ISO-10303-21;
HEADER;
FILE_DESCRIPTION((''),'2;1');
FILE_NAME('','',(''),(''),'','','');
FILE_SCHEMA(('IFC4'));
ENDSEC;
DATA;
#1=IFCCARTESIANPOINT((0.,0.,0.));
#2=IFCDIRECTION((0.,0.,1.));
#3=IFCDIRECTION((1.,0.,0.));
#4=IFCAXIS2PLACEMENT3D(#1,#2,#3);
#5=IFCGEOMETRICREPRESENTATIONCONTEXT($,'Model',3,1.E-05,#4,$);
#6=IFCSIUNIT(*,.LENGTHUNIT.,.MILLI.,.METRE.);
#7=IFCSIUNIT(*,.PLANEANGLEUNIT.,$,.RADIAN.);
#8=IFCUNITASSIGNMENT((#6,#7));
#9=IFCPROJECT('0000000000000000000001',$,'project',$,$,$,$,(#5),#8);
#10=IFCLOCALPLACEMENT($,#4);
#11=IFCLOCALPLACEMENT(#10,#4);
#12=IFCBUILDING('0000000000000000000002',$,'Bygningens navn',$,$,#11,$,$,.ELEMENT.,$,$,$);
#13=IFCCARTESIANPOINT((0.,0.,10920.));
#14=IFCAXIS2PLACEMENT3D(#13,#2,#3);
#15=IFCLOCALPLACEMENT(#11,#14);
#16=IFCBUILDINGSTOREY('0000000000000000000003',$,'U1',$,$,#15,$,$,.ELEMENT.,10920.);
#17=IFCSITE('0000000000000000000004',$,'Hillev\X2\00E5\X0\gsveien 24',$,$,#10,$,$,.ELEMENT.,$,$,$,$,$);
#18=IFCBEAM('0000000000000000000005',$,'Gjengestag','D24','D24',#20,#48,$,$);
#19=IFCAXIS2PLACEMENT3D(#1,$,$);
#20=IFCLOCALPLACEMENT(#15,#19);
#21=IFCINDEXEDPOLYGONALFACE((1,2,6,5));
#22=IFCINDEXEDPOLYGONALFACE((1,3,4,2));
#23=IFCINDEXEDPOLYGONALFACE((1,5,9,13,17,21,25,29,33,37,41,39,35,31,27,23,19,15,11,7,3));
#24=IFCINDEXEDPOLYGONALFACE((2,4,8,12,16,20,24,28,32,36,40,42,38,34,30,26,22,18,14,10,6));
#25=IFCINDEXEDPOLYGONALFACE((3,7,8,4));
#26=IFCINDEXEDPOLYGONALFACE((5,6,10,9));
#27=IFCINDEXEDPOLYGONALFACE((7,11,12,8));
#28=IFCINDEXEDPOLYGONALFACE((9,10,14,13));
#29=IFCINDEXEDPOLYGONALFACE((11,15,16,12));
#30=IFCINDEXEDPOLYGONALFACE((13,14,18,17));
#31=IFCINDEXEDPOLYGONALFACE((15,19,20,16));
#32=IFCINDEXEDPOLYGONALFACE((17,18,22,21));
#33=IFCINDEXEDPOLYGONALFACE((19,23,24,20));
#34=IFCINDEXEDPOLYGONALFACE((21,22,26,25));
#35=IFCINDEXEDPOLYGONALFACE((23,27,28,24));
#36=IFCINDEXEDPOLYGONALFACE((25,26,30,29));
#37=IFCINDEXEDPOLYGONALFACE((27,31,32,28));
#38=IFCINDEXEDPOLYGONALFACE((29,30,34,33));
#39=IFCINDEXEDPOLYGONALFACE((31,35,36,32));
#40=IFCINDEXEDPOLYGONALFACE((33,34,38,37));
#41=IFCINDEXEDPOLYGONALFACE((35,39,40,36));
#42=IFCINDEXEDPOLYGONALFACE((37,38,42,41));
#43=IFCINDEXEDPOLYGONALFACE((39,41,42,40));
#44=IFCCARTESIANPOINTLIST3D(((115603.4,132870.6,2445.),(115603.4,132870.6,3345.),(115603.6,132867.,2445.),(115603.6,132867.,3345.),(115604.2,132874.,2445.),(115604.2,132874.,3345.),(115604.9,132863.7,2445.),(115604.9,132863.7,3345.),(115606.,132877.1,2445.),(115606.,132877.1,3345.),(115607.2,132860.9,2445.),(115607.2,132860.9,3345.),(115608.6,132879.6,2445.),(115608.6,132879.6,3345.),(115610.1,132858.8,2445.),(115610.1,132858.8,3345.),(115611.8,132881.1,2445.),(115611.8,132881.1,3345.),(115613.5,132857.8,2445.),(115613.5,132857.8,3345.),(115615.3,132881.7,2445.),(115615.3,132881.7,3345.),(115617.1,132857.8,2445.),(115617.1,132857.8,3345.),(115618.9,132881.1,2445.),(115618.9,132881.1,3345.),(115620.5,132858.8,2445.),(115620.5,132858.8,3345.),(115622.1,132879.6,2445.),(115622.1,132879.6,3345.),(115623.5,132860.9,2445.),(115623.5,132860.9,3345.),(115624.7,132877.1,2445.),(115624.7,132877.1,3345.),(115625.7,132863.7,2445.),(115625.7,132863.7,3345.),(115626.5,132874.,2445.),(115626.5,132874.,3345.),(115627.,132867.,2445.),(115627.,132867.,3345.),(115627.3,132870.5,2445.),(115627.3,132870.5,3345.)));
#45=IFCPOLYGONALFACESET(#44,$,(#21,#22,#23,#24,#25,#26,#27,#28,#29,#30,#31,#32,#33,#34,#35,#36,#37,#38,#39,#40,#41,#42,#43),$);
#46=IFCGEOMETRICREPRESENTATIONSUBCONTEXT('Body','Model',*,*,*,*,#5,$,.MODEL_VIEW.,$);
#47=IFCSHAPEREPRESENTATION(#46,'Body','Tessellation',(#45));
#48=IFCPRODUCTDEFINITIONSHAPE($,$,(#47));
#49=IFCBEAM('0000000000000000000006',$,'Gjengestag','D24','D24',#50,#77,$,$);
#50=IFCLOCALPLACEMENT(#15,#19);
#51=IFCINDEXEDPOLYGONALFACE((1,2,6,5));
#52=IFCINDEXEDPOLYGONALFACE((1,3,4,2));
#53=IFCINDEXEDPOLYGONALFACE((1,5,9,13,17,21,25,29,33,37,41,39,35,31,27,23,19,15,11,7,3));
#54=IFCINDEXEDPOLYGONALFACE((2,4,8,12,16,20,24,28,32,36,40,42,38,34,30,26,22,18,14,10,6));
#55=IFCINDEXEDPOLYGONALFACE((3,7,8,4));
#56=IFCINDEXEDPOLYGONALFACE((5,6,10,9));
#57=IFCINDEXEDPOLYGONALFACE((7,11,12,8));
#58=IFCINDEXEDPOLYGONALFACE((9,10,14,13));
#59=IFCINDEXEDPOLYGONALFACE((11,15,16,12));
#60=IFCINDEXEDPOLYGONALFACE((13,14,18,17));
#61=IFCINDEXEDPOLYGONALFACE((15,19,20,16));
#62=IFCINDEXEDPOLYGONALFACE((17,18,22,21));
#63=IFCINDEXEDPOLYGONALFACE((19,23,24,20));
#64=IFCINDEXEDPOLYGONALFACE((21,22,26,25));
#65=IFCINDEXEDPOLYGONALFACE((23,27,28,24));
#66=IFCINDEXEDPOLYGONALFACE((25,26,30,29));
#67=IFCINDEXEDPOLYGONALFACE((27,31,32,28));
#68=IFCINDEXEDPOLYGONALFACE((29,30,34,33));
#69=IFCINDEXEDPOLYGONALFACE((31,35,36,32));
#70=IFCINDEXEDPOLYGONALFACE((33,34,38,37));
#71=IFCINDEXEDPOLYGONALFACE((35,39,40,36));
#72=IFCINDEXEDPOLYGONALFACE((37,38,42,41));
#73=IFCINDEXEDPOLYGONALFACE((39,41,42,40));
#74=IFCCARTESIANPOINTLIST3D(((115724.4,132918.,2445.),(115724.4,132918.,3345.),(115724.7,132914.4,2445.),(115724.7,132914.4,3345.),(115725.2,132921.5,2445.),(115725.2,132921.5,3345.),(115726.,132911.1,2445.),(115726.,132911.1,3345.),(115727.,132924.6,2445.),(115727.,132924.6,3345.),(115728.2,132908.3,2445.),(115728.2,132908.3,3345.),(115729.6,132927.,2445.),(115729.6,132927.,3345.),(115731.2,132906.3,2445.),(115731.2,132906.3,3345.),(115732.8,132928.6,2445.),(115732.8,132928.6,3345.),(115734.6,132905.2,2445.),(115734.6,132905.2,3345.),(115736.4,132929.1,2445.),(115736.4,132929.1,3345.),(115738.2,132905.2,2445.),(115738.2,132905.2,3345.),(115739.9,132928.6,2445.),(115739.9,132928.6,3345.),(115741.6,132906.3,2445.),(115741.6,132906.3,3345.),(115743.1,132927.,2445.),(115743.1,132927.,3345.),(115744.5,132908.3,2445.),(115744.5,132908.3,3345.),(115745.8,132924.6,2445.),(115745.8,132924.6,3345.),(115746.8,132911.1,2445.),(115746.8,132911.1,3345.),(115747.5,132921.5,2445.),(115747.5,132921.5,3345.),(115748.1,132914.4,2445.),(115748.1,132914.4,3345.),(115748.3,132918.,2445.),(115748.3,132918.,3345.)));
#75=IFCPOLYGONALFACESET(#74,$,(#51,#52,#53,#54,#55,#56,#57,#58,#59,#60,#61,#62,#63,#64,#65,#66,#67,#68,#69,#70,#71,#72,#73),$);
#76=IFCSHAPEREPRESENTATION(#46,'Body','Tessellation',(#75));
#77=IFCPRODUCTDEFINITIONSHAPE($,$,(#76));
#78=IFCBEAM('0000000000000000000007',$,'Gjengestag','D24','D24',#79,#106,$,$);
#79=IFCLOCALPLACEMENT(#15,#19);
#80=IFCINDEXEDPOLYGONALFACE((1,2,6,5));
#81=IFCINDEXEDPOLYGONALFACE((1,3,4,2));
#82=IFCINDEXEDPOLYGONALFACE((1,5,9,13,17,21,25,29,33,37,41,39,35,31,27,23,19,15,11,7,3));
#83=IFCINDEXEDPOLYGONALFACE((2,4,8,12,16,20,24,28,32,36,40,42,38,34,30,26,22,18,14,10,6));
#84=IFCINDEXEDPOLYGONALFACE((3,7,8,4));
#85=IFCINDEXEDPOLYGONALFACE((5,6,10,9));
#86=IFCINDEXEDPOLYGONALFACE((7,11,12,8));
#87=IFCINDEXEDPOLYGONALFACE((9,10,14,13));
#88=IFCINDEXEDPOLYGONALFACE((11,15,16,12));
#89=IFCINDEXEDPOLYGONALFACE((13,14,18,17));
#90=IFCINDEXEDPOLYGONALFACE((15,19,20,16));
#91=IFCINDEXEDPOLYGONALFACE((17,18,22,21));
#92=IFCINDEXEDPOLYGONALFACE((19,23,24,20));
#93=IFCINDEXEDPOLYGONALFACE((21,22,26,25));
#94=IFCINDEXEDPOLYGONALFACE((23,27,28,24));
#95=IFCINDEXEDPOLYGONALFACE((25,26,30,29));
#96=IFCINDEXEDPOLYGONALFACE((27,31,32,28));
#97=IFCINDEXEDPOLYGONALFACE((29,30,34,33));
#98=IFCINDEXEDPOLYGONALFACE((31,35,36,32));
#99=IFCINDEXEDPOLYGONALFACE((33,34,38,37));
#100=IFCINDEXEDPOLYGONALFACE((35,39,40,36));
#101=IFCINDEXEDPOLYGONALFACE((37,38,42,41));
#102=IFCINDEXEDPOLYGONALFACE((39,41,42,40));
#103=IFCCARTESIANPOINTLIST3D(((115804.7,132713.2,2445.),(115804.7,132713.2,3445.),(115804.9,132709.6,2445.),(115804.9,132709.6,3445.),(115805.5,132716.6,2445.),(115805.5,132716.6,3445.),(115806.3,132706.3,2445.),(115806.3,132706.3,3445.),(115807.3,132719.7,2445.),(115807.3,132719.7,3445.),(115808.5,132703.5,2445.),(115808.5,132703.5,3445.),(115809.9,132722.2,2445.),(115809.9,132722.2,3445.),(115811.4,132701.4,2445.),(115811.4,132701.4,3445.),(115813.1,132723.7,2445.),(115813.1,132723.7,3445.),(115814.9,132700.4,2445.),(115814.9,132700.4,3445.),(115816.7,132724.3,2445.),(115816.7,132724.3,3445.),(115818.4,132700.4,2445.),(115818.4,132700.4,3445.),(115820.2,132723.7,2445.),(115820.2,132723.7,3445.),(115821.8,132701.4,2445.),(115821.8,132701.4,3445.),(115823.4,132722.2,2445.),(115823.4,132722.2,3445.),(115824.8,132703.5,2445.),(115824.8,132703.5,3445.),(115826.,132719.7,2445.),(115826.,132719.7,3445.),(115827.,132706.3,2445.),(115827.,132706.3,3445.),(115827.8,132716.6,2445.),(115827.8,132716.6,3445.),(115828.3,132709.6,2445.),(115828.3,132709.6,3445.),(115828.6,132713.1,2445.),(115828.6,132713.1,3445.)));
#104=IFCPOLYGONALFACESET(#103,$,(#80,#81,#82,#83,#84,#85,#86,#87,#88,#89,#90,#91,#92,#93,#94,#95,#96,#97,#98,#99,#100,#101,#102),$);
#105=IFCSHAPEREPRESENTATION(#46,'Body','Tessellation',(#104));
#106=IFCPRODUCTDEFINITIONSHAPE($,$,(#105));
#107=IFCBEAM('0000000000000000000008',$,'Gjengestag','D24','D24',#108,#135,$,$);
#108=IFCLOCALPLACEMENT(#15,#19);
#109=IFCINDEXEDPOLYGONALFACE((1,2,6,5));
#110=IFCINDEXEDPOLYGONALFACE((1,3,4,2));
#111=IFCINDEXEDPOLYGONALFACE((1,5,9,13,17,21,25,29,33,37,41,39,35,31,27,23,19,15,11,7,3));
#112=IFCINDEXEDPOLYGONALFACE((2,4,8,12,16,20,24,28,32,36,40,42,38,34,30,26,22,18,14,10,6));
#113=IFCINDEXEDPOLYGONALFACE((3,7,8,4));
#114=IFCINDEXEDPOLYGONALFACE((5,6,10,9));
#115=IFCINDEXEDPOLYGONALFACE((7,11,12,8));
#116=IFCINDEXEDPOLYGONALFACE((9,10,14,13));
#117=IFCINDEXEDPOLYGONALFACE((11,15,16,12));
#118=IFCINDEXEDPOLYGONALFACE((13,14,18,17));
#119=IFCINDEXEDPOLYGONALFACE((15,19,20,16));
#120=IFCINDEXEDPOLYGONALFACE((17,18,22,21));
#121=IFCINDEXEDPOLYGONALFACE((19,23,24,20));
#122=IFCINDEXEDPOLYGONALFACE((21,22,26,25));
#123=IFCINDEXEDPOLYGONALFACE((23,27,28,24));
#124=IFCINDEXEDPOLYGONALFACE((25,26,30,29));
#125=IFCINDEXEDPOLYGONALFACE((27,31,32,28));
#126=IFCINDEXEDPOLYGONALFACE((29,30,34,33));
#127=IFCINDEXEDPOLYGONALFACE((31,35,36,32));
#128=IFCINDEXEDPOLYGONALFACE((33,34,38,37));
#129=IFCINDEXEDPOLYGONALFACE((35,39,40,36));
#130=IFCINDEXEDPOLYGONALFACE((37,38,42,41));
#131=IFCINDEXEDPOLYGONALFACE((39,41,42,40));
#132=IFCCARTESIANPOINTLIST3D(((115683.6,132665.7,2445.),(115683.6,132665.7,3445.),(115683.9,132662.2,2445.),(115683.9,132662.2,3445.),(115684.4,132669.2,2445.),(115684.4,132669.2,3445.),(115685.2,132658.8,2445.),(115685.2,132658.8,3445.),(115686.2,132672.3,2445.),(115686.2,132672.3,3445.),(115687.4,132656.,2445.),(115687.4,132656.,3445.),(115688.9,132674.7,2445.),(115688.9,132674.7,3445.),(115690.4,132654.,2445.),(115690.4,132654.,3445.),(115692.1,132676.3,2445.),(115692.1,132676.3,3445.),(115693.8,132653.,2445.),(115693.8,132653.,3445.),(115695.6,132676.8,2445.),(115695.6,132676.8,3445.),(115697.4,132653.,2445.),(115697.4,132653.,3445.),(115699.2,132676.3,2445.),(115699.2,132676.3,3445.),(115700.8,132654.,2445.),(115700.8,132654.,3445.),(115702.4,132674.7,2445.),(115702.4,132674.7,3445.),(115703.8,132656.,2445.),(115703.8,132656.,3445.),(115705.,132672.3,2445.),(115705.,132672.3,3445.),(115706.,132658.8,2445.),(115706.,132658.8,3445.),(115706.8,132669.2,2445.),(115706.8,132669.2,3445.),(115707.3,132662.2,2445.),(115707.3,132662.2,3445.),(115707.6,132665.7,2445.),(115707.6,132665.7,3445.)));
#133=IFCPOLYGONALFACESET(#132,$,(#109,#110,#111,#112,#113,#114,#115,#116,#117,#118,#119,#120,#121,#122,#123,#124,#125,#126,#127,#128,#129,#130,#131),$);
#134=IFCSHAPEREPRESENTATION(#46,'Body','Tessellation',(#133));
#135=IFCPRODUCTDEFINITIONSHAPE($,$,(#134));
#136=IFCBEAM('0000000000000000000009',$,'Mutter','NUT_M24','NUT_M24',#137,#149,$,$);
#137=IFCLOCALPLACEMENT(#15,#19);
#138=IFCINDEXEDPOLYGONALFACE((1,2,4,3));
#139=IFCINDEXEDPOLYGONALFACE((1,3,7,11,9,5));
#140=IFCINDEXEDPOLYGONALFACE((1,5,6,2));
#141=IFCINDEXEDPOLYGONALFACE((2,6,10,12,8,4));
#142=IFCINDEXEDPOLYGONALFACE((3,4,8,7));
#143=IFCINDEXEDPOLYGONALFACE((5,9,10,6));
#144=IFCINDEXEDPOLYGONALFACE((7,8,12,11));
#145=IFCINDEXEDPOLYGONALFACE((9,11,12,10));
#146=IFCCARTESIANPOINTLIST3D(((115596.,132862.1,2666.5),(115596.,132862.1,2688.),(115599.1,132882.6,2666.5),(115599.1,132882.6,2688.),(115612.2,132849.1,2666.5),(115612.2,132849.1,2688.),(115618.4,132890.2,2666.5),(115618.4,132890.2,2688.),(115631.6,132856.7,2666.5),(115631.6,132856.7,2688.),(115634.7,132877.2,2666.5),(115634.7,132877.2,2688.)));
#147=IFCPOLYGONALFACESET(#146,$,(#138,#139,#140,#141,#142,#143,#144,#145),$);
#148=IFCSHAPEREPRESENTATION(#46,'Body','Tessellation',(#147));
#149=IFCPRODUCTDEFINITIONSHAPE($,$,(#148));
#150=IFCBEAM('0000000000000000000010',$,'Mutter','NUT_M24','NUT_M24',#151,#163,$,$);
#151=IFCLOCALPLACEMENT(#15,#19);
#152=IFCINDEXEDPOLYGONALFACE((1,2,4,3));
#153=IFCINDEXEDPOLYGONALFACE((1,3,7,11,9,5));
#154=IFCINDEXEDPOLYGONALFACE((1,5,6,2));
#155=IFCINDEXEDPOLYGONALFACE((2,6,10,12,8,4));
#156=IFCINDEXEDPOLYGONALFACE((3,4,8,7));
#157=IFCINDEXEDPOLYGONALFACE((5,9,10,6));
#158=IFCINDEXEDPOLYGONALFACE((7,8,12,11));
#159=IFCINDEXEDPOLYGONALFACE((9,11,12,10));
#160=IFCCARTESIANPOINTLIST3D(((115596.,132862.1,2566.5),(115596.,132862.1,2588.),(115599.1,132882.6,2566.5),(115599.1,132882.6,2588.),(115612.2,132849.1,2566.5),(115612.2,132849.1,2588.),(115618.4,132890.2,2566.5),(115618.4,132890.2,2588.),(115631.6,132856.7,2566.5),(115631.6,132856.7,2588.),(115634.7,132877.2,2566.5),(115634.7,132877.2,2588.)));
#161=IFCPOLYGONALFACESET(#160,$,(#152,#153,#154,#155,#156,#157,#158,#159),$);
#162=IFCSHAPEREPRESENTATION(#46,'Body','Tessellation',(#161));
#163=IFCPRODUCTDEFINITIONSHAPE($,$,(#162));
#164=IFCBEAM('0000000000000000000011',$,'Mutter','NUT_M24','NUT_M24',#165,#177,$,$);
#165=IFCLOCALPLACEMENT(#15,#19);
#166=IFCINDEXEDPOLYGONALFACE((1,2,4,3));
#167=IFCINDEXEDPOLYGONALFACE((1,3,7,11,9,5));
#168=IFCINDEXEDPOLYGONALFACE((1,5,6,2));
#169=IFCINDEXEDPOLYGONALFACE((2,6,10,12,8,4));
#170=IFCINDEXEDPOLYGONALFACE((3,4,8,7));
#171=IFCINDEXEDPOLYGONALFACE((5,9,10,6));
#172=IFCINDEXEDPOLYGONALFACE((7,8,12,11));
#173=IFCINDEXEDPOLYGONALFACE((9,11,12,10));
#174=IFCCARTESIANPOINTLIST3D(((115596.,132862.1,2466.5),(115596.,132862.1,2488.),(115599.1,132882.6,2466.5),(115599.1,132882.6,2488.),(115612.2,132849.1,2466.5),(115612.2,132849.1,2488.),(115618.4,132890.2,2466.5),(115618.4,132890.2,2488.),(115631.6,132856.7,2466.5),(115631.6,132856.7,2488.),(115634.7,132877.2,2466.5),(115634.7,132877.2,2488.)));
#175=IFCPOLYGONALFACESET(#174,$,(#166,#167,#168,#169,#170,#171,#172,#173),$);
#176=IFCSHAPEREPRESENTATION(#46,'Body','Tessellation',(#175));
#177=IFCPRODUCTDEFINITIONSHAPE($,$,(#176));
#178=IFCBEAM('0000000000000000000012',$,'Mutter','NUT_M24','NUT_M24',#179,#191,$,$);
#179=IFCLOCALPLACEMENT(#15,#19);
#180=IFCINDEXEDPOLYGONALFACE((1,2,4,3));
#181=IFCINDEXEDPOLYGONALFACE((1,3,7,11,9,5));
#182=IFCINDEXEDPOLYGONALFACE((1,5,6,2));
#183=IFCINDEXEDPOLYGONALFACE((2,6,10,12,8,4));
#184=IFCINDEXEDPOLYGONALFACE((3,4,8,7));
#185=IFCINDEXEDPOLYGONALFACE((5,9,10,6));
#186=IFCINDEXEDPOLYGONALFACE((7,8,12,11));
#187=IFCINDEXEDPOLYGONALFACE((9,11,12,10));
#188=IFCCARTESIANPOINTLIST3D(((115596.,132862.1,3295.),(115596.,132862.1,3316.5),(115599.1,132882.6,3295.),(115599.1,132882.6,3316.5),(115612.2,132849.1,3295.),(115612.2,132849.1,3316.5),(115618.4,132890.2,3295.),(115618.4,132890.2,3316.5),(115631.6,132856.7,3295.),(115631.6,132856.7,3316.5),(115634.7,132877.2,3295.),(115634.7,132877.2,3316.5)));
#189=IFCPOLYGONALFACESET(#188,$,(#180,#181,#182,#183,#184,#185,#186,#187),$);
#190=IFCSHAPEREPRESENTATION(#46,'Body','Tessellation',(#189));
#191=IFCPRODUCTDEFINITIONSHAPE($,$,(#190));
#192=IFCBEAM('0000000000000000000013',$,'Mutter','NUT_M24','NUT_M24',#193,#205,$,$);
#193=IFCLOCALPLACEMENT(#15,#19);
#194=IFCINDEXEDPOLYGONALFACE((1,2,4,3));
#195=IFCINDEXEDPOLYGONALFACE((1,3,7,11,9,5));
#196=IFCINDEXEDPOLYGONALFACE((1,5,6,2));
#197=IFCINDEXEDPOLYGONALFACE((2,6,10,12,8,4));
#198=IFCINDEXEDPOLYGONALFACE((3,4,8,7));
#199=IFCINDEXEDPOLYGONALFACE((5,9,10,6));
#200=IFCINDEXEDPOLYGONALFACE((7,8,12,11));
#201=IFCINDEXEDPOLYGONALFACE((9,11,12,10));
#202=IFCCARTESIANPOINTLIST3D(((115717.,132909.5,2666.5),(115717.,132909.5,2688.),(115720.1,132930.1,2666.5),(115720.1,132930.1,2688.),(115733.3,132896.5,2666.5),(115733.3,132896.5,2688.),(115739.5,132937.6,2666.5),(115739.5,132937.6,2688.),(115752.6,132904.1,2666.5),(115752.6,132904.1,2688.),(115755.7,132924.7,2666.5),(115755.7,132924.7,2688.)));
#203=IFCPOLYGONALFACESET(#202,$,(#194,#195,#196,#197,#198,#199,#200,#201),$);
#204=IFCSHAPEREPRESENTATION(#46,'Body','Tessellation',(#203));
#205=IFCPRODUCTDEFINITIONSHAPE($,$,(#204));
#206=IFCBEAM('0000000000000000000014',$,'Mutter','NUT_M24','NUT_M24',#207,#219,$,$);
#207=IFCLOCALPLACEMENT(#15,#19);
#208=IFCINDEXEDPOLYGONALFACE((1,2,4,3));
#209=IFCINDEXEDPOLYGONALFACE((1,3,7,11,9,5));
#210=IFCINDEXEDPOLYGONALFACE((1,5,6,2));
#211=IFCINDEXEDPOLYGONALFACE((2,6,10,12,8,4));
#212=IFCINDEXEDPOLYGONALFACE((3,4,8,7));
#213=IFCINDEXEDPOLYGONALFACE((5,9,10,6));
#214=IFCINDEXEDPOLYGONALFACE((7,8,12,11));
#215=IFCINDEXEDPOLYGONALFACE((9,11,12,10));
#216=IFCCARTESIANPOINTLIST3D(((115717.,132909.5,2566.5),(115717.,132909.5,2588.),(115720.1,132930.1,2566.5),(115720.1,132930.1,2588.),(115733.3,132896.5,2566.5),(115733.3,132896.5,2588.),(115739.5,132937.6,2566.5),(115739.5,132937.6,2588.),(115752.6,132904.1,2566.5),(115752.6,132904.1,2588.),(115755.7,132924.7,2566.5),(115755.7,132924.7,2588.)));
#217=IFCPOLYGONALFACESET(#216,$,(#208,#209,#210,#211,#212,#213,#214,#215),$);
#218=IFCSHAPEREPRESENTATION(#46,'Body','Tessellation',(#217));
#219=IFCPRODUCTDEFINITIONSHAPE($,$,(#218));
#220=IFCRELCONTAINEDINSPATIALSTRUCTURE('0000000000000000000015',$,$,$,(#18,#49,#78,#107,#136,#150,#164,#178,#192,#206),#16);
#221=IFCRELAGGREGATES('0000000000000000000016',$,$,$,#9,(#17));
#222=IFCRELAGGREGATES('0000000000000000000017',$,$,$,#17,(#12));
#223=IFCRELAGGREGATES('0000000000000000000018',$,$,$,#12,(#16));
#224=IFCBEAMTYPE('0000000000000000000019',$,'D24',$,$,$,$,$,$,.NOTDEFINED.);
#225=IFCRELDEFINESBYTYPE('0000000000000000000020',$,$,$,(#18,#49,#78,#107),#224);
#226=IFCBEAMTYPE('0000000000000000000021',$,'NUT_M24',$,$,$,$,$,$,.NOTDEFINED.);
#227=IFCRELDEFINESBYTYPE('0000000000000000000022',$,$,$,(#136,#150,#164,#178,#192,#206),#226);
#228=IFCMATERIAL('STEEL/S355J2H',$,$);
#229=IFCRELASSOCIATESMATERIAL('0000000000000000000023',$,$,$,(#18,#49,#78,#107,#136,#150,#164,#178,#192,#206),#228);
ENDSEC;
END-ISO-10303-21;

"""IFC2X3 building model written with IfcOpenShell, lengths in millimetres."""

from ifc_helpers import new_model, si_unit, frame, frame_2d, origin_with_axes, place, context, subcontext, project, spatial, polyline, circle, outline, extrude, material, type_object, element, save


model = new_model("IFC2X3")

# Units and contexts
model_context = context("Model", 3, precision=1e-05, world=origin_with_axes())
body_context = subcontext(model_context, "Body", "Model", "MODEL_VIEW")
ifc_project = project(units=[si_unit("LENGTHUNIT", "METRE", prefix="MILLI"), si_unit("PLANEANGLEUNIT", "RADIAN")], contexts=[model_context])

# Site, building, storey
site_placement = place(None, origin_with_axes())
site = spatial("IfcSite", under=ifc_project, at=site_placement, Name="Hillevågsveien 24", CompositionType="ELEMENT")
building_placement = place(site_placement, origin_with_axes())
building = spatial("IfcBuilding", under=site, at=building_placement, Name="Bygningens navn", CompositionType="ELEMENT")
storey_placement = place(building_placement, frame((0.0, 0.0, 10920.0), z_axis=(0.0, 0.0, 1.0), x_axis=(1.0, 0.0, 0.0)))
storey = spatial("IfcBuildingStorey", under=building, at=storey_placement, Name="U1", CompositionType="ELEMENT", Elevation=10920.0)

# Beams
ifc_material_1 = material(Name="STEEL/S355J2H")
beam_type_1 = type_object("IfcBeamType", Name="D24", PredefinedType="NOTDEFINED")
for number, where, z_axis, x_axis, name in (
    (1, (115615.3, 132869.7, 3345.0), (-0.364877, 0.931056, 0.0), (0.0, 0.0, -1.0), "Gjengestag"),
    (2, (115736.4, 132917.1, 3345.0), (-0.364877, 0.931056, 0.0), (0.0, 0.0, -1.0), "Gjengestag"),
):
    element("IfcBeam", number, at=place(storey_placement, frame(where, z_axis=z_axis, x_axis=x_axis)), inside=storey, type_object=beam_type_1, material=ifc_material_1, Name=name, Description="D24", ObjectType="D24", context=body_context, shape_type="SweptSolid", body=[
        extrude(circle(Radius=12.0, at=frame_2d((0.0, 0.0), x_axis=(1.0, 0.0))), frame((900.0, 0.0, 0.0), z_axis=(-1.0, 0.0, 0.0), x_axis=(0.0, -1.0, 0.0)), (0.0, 0.0, 1.0), 900.0),
    ])
for number, where, z_axis, x_axis, name in (
    (3, (115816.6, 132712.3, 3445.0), (-0.364877, 0.931056, 0.0), (0.0, 0.0, -1.0), "Gjengestag"),
    (4, (115695.6, 132664.8, 3445.0), (-0.364877, 0.931056, 0.0), (0.0, 0.0, -1.0), "Gjengestag"),
):
    element("IfcBeam", number, at=place(storey_placement, frame(where, z_axis=z_axis, x_axis=x_axis)), inside=storey, type_object=beam_type_1, material=ifc_material_1, Name=name, Description="D24", ObjectType="D24", context=body_context, shape_type="SweptSolid", body=[
        extrude(circle(Radius=12.0, at=frame_2d((0.0, 0.0), x_axis=(1.0, 0.0))), frame((1000.0, 0.0, 0.0), z_axis=(-1.0, 0.0, 0.0), x_axis=(0.0, -1.0, 0.0)), (0.0, 0.0, 1.0), 1000.0),
    ])
beam_type_2 = type_object("IfcBeamType", Name="NUT_M24", PredefinedType="NOTDEFINED")
for number, where, z_axis, x_axis, name in (
    (5, (115615.3, 132869.7, 2688.0), (-0.364877, 0.931056, 0.0), (0.0, 0.0, -1.0), "Mutter"),
    (6, (115615.3, 132869.7, 2588.0), (-0.364877, 0.931056, 0.0), (0.0, 0.0, -1.0), "Mutter"),
    (7, (115615.3, 132869.7, 2488.0), (-0.364877, 0.931056, 0.0), (0.0, 0.0, -1.0), "Mutter"),
    (8, (115615.3, 132869.7, 3316.5), (-0.364877, 0.931056, 0.0), (0.0, 0.0, -1.0), "Mutter"),
    (9, (115736.4, 132917.1, 2688.0), (-0.364877, 0.931056, 0.0), (0.0, 0.0, -1.0), "Mutter"),
    (10, (115736.4, 132917.1, 2588.0), (-0.364877, 0.931056, 0.0), (0.0, 0.0, -1.0), "Mutter"),
):
    element("IfcBeam", number, at=place(storey_placement, frame(where, z_axis=z_axis, x_axis=x_axis)), inside=storey, type_object=beam_type_2, material=ifc_material_1, Name=name, Description="NUT_M24", ObjectType="NUT_M24", context=body_context, shape_type="SweptSolid", body=[
        extrude(outline(polyline([(-10.4, 18.0), (10.4, 18.0), (20.8, 0.0), (10.4, -18.0), (-10.4, -18.0), (-20.8, 0.0), (-10.4, 18.0)])), frame((21.5, 0.0, 0.0), z_axis=(-1.0, 0.0, 0.0), x_axis=(0.0, -1.0, 0.0)), (0.0, 0.0, 1.0), 21.5),
    ])

save(model, "model.ifc")
